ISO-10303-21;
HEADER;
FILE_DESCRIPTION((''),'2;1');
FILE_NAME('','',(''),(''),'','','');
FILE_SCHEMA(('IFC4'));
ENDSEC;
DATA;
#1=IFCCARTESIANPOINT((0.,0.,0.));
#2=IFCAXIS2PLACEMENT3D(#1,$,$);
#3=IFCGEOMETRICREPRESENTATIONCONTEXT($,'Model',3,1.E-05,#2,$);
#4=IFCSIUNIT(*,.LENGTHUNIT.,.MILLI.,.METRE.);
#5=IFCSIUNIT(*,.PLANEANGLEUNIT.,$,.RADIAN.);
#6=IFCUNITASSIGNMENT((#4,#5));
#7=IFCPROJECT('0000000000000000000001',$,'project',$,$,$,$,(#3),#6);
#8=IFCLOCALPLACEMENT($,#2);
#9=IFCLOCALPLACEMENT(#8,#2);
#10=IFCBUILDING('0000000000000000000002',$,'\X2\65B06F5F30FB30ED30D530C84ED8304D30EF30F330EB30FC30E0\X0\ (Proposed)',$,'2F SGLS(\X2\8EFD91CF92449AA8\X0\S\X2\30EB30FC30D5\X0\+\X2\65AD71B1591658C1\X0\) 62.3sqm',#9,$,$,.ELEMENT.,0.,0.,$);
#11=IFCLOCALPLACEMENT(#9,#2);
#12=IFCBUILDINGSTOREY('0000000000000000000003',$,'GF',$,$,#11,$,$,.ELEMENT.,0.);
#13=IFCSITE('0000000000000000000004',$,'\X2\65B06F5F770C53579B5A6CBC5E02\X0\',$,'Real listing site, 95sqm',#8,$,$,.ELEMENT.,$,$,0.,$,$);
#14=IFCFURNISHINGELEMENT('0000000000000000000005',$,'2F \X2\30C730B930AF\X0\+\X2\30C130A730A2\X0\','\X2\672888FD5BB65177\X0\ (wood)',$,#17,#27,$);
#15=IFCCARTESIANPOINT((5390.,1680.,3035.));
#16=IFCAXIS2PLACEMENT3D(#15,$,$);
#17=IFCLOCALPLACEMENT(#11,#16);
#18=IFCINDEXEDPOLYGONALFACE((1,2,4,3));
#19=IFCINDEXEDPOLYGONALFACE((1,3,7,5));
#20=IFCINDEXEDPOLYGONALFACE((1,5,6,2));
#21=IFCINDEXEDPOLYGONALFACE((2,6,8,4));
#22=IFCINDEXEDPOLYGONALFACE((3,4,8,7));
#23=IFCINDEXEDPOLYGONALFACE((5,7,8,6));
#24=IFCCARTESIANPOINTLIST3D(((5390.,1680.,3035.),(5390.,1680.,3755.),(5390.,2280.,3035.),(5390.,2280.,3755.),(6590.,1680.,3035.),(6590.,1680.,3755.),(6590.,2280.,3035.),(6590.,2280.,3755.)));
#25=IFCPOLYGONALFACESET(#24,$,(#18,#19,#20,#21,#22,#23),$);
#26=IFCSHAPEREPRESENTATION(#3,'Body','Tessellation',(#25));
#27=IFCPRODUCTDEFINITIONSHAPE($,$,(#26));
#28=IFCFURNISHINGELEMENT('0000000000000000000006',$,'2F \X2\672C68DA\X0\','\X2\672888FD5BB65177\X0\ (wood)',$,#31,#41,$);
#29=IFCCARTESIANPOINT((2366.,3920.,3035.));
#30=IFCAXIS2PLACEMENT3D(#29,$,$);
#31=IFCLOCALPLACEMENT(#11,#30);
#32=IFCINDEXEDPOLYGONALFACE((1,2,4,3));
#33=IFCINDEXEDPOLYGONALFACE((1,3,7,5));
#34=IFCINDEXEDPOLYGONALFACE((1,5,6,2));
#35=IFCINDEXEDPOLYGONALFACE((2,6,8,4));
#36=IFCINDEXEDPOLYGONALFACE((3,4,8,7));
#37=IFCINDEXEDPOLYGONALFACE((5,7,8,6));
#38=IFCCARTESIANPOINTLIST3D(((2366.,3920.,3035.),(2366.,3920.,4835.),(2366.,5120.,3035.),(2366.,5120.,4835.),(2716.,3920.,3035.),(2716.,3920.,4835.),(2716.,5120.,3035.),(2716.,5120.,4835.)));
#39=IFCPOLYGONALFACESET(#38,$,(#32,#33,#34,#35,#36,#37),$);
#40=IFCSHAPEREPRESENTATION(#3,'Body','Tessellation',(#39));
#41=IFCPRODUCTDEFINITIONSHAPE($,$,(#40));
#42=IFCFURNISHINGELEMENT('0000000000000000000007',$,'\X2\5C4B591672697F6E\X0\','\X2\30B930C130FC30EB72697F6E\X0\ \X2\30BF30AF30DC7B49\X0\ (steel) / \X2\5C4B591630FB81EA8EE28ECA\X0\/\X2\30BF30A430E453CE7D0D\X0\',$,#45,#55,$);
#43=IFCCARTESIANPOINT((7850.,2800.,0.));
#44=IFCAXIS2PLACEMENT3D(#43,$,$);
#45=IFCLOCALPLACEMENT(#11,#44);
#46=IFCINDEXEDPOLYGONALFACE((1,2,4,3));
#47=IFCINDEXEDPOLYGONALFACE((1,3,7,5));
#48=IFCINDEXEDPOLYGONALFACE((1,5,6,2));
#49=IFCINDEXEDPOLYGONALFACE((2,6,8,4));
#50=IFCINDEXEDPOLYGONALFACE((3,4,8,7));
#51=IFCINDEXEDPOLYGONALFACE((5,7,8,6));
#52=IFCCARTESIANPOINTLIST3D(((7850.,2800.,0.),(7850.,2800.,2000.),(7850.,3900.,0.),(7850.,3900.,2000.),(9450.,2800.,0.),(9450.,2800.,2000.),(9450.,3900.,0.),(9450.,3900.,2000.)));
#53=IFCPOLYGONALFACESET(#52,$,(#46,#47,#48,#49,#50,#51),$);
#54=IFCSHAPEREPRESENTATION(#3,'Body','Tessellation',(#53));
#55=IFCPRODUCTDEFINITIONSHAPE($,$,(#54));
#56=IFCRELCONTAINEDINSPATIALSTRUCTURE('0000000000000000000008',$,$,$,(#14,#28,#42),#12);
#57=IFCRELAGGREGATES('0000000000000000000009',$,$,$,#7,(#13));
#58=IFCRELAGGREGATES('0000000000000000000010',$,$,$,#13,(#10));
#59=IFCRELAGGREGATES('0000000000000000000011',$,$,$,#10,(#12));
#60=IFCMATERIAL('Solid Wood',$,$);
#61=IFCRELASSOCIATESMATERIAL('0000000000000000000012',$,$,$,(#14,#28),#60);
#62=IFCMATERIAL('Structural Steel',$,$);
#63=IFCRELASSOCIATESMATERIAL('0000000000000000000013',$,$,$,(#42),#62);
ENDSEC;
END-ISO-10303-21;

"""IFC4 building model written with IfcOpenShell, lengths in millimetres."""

from ifc_helpers import new_model, si_unit, frame, frame_2d, origin, place, context, project, spatial, rectangle, extrude, material, element, save


model = new_model("IFC4")

# Units and contexts
model_context = context("Model", 3, precision=1e-05, world=origin())
ifc_project = project(units=[si_unit("LENGTHUNIT", "METRE", prefix="MILLI"), si_unit("PLANEANGLEUNIT", "RADIAN")], contexts=[model_context])

# Site, building, storey
site_placement = place(None, origin())
site = spatial("IfcSite", under=ifc_project, at=site_placement, Name="新潟県南魚沼市", ObjectType="Real listing site, 95sqm", CompositionType="ELEMENT", RefElevation=0.0)
building_placement = place(site_placement, origin())
building = spatial("IfcBuilding", under=site, at=building_placement, Name="新潟・ロフト付きワンルーム (Proposed)", ObjectType="2F SGLS(軽量鉄骨Sルーフ+断熱外壁) 62.3sqm", CompositionType="ELEMENT", ElevationOfRefHeight=0.0, ElevationOfTerrain=0.0)
storey_placement = place(building_placement, origin())
storey = spatial("IfcBuildingStorey", under=building, at=storey_placement, Name="GF", CompositionType="ELEMENT", Elevation=0.0)

# Shared definitions
ifc_material_1 = material(Name="Solid Wood")

# Shared definitions
ifc_material_2 = material(Name="Structural Steel")

# Furnishing elements
furnishing_1_placement = place(storey_placement, frame((5390.0, 1680.0, 3035.0)))
element("IfcFurnishingElement", 1, at=furnishing_1_placement, inside=storey, material=ifc_material_1, Name="2F デスク+チェア", Description="木製家具 (wood)", context=model_context, shape_type="SweptSolid", body=[
    extrude(rectangle(XDim=1200.0, YDim=600.0, at=frame_2d((600.0, 300.0))), frame((5390.0, 1680.0, 3035.0)), (0.0, 0.0, 1.0), 720.0),
])
furnishing_2_placement = place(storey_placement, frame((2366.0, 3920.0, 3035.0)))
element("IfcFurnishingElement", 2, at=furnishing_2_placement, inside=storey, material=ifc_material_1, Name="2F 本棚", Description="木製家具 (wood)", context=model_context, shape_type="SweptSolid", body=[
    extrude(rectangle(XDim=350.0, YDim=1200.0, at=frame_2d((175.0, 600.0))), frame((2366.0, 3920.0, 3035.0)), (0.0, 0.0, 1.0), 1800.0),
])
furnishing_3_placement = place(storey_placement, frame((7850.0, 2800.0, 0.0)))
element("IfcFurnishingElement", 3, at=furnishing_3_placement, inside=storey, material=ifc_material_2, Name="屋外物置", Description="スチール物置 タクボ等 (steel) / 屋外・自転車/タイヤ収納", context=model_context, shape_type="SweptSolid", body=[
    extrude(rectangle(XDim=1600.0, YDim=1100.0, at=frame_2d((800.0, 550.0))), frame((7850.0, 2800.0, 0.0)), (0.0, 0.0, 1.0), 2000.0),
])

save(model, "model.ifc")
